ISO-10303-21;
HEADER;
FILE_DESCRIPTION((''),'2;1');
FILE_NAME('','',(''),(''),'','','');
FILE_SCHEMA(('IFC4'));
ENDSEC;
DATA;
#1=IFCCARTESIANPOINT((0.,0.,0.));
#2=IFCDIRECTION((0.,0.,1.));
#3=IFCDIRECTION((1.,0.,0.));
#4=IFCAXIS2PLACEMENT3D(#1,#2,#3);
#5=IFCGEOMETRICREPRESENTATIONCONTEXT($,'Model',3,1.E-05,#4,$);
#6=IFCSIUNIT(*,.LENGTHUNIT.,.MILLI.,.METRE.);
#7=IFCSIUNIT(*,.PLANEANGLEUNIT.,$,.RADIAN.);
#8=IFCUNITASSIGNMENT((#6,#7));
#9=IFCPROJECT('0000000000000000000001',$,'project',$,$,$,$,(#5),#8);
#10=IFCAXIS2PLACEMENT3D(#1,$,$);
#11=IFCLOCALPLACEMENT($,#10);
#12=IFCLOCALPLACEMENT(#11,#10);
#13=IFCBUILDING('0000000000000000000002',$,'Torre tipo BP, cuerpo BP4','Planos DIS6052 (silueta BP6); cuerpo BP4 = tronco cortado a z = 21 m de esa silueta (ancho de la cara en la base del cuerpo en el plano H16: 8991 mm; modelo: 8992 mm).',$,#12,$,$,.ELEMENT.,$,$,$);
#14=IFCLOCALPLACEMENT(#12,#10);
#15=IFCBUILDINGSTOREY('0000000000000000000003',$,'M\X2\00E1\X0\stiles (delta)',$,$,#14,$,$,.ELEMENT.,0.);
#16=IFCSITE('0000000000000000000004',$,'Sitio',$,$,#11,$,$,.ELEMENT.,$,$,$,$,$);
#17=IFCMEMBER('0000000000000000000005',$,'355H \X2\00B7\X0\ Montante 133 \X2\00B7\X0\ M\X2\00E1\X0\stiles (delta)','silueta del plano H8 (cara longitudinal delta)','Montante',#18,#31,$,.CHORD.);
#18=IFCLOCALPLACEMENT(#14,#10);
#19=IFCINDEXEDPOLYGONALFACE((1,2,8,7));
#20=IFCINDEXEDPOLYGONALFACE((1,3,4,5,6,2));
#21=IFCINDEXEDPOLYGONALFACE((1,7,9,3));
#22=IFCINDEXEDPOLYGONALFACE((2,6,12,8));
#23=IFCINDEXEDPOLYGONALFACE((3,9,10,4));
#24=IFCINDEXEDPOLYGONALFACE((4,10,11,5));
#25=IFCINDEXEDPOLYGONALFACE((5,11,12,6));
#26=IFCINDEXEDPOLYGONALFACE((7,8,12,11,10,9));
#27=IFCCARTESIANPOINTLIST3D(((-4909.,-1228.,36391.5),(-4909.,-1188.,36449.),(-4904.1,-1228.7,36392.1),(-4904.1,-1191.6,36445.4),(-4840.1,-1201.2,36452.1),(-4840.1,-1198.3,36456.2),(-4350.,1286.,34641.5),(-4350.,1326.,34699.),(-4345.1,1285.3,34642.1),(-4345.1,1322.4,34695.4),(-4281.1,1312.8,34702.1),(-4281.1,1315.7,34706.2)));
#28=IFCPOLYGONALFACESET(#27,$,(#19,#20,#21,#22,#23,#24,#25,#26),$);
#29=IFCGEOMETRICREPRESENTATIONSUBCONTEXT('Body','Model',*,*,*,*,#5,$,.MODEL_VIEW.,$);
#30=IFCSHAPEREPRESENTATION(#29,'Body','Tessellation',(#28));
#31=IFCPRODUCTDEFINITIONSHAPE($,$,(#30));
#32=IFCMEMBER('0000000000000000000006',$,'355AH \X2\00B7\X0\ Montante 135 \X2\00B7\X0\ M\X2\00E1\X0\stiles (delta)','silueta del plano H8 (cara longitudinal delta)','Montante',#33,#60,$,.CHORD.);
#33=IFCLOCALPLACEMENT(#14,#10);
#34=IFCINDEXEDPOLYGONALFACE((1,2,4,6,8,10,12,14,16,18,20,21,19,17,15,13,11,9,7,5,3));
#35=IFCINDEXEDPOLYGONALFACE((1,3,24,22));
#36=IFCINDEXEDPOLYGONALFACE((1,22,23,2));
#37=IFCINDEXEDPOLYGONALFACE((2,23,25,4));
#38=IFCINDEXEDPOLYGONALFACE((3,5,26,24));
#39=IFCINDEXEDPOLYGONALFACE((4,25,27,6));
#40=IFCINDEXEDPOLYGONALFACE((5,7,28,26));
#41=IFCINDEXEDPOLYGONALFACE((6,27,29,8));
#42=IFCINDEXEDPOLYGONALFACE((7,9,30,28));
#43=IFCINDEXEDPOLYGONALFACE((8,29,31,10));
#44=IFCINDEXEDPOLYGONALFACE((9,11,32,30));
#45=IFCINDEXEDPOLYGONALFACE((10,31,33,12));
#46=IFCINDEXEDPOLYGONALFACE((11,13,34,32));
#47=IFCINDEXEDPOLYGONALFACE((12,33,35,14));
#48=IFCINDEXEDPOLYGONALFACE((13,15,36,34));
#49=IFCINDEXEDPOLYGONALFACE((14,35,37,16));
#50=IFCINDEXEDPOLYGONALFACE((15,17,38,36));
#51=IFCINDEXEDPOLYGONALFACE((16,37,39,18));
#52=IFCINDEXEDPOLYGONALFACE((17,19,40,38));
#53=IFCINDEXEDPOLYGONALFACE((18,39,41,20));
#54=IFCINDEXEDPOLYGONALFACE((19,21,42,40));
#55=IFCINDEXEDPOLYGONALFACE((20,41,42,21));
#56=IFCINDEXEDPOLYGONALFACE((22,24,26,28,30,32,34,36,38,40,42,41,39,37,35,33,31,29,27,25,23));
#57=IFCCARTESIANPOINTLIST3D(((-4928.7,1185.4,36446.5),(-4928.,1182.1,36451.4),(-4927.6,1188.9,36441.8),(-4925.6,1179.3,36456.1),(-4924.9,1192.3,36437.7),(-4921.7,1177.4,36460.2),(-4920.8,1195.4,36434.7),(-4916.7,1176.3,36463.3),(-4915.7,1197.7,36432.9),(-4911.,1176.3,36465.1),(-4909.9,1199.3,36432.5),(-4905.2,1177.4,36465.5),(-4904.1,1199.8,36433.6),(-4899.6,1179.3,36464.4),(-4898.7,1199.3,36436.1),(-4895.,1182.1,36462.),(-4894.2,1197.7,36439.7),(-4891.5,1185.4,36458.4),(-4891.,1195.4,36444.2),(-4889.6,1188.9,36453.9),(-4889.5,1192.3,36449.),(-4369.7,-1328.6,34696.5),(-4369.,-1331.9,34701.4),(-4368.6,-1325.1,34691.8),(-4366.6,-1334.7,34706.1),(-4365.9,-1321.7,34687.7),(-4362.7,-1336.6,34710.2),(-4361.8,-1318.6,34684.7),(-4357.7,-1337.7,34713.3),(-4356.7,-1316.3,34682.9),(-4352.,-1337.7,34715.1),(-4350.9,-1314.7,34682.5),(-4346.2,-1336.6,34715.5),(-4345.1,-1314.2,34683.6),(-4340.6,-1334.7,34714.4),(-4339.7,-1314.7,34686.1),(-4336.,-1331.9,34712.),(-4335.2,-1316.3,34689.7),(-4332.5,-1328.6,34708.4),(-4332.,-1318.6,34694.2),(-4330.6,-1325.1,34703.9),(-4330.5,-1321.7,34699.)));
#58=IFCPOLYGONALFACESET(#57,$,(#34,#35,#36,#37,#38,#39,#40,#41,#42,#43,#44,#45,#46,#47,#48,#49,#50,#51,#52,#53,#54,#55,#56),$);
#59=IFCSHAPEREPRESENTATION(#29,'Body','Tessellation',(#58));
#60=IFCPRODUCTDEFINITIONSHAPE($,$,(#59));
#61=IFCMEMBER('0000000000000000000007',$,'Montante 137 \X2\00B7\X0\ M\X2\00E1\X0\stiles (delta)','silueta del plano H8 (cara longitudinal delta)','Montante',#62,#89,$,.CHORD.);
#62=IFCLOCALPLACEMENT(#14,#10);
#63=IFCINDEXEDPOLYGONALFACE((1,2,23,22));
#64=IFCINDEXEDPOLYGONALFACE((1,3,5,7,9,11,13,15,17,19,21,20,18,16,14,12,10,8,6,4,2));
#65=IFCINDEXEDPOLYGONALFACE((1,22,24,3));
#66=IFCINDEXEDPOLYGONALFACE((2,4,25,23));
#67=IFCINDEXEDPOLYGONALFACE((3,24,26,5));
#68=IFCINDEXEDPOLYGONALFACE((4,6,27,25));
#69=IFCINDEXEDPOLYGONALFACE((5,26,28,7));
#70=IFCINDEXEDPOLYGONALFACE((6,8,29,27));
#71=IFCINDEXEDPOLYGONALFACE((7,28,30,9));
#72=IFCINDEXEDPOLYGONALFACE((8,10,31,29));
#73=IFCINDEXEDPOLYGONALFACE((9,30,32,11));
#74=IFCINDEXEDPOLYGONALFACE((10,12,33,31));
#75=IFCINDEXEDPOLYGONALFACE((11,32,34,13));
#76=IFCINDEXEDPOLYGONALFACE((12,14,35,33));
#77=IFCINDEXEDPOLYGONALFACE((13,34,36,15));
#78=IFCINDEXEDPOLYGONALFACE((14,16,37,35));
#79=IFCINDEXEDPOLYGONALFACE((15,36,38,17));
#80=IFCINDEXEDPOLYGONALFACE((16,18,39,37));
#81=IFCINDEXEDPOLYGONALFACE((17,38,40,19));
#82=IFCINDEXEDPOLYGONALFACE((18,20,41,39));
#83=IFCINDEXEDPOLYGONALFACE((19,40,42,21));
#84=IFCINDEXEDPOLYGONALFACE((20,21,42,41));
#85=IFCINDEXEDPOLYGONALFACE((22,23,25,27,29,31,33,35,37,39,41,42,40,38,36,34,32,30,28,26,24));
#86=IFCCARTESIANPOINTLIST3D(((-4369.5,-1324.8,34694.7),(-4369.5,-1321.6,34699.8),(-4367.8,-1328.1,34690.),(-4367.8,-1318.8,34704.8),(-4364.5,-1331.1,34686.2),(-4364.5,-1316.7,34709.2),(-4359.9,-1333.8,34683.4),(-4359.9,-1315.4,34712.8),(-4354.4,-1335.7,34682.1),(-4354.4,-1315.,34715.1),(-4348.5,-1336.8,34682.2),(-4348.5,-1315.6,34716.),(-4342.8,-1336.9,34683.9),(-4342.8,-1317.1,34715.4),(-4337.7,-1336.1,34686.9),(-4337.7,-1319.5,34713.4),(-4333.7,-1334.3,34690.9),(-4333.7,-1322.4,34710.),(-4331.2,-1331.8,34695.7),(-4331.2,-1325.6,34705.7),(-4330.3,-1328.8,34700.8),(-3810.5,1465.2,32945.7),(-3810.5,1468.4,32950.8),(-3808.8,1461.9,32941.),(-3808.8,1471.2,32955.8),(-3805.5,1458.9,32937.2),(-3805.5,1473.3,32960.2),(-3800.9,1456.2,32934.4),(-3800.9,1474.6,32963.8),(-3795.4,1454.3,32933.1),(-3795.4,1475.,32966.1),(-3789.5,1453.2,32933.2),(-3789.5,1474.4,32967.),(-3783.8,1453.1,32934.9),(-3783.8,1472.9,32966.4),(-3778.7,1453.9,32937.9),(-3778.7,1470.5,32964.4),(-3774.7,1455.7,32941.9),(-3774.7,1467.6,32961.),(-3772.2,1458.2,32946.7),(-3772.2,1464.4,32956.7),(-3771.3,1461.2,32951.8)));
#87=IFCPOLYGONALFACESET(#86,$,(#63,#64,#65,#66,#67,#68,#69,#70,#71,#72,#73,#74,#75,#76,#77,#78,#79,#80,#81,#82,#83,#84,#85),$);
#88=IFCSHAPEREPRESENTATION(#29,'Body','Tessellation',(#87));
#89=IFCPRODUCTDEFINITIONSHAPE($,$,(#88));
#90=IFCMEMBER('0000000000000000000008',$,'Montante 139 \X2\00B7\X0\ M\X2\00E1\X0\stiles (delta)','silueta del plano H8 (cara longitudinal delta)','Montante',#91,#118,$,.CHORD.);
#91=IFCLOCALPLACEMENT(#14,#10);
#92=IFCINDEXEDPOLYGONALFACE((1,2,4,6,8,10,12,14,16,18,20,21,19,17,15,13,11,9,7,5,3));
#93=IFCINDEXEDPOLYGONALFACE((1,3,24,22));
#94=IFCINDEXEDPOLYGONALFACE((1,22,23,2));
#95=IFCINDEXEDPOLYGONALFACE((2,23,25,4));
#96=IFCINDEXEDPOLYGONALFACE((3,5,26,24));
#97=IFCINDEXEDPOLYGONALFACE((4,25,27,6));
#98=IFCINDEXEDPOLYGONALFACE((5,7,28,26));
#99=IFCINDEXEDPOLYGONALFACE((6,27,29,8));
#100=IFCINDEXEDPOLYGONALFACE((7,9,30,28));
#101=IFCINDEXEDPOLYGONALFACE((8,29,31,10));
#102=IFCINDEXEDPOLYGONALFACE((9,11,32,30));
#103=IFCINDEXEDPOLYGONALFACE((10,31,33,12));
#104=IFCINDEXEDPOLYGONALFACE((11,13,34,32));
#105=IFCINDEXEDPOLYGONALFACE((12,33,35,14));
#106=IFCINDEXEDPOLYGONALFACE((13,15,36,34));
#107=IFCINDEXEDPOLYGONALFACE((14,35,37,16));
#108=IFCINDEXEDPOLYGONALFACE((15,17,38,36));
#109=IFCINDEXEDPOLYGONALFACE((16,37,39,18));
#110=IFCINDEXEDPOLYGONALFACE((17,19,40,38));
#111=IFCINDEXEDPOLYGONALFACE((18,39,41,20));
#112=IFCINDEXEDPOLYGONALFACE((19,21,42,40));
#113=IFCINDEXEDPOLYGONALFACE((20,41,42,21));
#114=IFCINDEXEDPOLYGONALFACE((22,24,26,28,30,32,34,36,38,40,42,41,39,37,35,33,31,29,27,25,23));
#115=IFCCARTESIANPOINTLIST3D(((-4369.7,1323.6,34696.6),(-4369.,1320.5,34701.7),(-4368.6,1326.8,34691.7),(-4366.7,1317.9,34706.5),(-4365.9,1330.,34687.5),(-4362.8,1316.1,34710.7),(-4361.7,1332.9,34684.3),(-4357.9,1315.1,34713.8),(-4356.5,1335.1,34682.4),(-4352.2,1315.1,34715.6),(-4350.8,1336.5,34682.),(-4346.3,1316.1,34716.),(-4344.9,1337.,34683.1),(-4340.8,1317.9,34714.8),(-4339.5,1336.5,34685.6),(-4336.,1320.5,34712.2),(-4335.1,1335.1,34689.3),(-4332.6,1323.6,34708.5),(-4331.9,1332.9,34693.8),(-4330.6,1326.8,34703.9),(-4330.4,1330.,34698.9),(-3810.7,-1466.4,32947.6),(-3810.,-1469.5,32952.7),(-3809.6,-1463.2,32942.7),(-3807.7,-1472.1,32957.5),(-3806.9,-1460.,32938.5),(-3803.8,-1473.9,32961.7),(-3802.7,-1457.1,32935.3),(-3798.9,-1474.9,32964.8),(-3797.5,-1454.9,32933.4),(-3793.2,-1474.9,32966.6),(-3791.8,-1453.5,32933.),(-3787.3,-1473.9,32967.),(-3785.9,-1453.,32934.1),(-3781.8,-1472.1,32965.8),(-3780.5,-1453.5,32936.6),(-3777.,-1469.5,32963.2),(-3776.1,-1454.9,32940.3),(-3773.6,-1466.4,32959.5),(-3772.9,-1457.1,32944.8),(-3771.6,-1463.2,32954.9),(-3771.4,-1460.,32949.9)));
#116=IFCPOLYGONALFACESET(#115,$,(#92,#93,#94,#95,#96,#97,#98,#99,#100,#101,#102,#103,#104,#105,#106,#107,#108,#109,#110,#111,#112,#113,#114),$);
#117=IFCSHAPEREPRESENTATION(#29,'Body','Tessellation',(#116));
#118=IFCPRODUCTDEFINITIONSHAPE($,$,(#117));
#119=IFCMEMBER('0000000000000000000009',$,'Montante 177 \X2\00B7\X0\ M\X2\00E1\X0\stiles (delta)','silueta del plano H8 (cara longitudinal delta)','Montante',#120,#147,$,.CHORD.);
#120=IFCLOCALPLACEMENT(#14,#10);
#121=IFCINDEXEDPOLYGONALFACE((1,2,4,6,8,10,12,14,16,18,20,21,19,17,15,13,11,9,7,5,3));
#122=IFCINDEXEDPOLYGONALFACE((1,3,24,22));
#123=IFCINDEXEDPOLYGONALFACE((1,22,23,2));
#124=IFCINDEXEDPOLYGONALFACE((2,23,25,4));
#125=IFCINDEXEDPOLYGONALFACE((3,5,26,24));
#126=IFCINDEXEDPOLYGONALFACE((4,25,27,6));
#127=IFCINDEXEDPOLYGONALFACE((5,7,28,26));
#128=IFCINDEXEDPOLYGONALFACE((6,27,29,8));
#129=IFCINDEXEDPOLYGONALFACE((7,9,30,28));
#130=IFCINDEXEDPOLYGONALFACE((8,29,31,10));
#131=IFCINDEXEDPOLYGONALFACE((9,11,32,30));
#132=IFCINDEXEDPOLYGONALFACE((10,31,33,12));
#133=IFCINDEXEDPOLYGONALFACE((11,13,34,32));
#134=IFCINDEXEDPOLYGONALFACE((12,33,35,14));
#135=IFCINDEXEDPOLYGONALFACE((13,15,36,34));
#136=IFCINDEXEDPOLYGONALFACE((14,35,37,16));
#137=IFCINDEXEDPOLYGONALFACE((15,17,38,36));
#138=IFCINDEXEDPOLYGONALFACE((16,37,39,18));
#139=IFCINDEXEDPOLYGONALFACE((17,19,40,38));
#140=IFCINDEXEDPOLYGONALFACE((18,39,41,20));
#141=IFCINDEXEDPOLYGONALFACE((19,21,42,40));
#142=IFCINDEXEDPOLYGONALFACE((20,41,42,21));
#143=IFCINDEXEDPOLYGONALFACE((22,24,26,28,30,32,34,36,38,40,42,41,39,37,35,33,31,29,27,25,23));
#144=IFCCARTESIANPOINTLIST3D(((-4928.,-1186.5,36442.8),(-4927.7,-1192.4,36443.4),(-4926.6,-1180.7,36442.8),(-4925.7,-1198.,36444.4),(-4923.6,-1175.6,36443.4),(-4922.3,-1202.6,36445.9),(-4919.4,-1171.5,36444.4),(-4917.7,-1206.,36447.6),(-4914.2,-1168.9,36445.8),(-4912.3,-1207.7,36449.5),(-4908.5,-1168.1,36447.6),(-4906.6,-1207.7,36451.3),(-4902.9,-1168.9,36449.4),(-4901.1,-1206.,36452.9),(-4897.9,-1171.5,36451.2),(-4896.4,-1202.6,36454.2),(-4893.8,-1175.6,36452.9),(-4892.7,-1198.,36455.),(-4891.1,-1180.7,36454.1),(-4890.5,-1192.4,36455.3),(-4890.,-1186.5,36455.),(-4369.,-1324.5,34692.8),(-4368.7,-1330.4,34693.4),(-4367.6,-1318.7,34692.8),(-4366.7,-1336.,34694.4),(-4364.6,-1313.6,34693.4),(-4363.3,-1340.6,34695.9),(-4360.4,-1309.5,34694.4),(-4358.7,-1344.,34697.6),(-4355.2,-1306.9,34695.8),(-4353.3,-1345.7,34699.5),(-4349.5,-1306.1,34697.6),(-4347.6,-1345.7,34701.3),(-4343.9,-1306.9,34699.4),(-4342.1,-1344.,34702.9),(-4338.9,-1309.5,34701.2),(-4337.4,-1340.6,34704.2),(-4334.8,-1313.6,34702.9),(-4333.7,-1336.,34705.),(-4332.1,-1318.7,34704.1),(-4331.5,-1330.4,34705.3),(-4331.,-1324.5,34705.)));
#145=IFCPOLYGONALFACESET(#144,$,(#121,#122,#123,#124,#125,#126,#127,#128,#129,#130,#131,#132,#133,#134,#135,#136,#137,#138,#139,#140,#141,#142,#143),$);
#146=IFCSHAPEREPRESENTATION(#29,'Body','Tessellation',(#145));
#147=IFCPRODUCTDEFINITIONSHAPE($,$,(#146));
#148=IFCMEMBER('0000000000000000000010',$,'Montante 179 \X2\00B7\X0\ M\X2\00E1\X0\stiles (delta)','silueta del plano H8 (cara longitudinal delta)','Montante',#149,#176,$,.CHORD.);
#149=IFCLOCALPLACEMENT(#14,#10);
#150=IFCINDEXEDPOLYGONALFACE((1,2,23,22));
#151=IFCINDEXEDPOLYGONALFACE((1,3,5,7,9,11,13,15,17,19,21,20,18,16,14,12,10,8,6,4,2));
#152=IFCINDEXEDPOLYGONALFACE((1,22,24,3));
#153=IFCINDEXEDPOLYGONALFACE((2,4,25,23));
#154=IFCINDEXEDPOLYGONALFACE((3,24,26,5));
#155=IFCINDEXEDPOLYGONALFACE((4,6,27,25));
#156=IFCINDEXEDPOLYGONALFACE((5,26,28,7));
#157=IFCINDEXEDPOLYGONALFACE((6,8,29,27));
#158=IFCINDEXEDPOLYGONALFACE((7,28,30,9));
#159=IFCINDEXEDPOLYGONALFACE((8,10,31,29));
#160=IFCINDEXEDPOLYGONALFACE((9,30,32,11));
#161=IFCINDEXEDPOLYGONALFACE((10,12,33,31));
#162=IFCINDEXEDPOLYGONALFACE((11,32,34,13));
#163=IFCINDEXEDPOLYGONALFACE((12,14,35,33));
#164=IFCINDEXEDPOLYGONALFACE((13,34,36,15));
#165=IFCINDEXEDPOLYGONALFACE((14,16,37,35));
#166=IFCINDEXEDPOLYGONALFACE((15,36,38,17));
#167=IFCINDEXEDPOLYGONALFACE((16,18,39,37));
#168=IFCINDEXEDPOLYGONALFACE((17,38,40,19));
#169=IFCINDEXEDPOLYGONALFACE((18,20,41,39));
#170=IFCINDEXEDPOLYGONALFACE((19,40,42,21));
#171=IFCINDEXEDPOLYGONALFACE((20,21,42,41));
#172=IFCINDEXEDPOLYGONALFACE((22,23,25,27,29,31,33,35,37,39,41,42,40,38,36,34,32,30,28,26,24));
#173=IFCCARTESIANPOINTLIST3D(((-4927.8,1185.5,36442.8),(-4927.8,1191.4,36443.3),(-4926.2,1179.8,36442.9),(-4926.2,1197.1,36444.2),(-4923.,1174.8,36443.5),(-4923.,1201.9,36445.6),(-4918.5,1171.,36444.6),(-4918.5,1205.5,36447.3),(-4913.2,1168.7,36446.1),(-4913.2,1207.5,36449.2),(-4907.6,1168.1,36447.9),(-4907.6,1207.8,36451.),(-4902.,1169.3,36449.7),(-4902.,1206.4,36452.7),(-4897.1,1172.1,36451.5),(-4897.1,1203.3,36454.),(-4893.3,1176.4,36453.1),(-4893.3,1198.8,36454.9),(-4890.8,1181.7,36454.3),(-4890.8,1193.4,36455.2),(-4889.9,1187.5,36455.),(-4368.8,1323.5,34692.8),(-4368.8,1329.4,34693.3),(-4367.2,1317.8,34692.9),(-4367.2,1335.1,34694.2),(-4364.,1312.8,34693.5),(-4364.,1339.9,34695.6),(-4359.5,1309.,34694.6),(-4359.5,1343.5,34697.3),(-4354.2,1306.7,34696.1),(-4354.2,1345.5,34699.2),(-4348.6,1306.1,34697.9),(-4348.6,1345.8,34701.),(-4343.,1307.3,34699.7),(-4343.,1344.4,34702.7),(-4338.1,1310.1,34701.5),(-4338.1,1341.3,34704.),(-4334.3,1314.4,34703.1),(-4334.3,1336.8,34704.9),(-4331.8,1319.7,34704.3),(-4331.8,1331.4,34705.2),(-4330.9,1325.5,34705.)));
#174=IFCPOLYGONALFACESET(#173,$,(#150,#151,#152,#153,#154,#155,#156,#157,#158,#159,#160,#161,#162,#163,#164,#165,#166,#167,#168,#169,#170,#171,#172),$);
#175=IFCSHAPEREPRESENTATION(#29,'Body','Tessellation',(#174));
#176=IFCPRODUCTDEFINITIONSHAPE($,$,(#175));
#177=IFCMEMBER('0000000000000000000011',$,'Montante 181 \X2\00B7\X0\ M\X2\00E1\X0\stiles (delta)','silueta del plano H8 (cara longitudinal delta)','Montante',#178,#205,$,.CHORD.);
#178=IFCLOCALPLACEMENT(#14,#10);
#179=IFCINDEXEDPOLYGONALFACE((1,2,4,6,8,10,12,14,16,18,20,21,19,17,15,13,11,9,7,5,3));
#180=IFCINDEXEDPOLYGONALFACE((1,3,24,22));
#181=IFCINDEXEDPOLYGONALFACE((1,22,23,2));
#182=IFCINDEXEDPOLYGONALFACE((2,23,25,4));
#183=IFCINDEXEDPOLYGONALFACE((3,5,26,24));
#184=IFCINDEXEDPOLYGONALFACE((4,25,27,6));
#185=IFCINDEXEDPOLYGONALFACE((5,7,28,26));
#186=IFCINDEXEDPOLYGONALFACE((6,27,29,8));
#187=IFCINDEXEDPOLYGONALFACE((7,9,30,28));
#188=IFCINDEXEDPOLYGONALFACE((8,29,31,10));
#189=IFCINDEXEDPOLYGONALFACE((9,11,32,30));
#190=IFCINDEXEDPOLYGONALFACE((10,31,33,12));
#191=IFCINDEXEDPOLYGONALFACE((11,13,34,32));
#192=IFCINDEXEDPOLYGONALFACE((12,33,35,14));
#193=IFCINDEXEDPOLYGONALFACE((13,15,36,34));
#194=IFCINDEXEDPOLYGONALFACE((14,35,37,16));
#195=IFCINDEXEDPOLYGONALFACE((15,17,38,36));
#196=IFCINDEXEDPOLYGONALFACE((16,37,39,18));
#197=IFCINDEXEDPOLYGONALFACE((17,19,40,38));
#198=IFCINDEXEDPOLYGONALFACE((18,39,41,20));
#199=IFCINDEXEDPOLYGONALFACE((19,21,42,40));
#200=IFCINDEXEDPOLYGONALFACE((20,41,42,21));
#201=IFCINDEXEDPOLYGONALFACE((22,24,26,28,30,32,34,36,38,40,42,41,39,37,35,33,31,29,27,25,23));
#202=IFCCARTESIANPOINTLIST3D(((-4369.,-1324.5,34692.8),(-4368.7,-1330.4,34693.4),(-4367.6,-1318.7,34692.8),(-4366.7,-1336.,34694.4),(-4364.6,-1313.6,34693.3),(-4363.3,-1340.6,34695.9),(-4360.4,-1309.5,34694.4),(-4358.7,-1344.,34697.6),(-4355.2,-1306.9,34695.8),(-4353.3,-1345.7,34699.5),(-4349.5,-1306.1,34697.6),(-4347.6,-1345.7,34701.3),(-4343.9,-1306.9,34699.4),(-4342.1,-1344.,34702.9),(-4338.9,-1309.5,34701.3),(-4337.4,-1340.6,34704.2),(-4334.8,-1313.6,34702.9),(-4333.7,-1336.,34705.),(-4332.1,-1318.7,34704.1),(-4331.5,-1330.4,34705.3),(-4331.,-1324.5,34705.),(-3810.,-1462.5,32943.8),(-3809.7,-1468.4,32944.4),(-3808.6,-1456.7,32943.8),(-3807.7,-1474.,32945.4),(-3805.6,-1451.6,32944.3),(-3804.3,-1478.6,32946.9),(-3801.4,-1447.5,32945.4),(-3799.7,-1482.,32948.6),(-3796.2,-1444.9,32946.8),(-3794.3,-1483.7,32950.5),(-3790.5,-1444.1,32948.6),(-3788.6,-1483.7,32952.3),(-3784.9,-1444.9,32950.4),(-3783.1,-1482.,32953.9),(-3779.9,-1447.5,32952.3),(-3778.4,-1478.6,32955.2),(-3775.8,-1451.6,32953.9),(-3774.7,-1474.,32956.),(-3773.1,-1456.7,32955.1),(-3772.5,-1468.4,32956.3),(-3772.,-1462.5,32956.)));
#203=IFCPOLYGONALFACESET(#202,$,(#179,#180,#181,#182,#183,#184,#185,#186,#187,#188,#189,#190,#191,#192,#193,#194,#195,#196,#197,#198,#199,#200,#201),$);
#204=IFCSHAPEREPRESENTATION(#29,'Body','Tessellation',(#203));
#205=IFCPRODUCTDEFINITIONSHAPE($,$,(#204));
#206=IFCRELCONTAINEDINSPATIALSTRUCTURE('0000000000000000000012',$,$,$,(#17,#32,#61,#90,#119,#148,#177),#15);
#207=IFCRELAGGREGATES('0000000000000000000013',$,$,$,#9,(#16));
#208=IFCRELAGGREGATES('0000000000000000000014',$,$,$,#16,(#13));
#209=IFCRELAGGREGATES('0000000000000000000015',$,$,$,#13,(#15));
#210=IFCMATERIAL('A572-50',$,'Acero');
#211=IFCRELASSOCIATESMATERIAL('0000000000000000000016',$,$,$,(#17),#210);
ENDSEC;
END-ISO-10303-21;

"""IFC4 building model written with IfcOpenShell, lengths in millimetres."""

from ifc_helpers import new_model, si_unit, frame, frame_2d, origin, origin_with_axes, place, context, subcontext, project, spatial, circle, l_section, extrude, material, element, save


model = new_model("IFC4")

# Units and contexts
model_context = context("Model", 3, precision=1e-05, world=origin_with_axes())
body_context = subcontext(model_context, "Body", "Model", "MODEL_VIEW")
ifc_project = project(units=[si_unit("LENGTHUNIT", "METRE", prefix="MILLI"), si_unit("PLANEANGLEUNIT", "RADIAN")], contexts=[model_context])

# Site, building, storey
site_placement = place(None, origin())
site = spatial("IfcSite", under=ifc_project, at=site_placement, Name="Sitio", CompositionType="ELEMENT")
building_placement = place(site_placement, origin())
building = spatial("IfcBuilding", under=site, at=building_placement, Name="Torre tipo BP, cuerpo BP4", Description="Planos DIS6052 (silueta BP6); cuerpo BP4 = tronco cortado a z = 21 m de esa silueta (ancho de la cara en la base del cuerpo en el plano H16: 8991 mm; modelo: 8992 mm).", CompositionType="ELEMENT")
storey_placement = place(building_placement, origin())
storey = spatial("IfcBuildingStorey", under=building, at=storey_placement, Name="Mástiles (delta)", CompositionType="ELEMENT", Elevation=0.0)

# Members
ifc_material = material(Name="A572-50", Category="Acero")
member_1_placement = place(storey_placement, frame((-4909.0, -1188.0, 36449.0), z_axis=(0.179529, 0.807398, -0.562031), x_axis=(0.983753, -0.147345, 0.102567)))
element("IfcMember", 1, at=member_1_placement, inside=storey, material=ifc_material, Name="355H · Montante 133 · Mástiles (delta)", Description="silueta del plano H8 (cara longitudinal delta)", ObjectType="Montante", PredefinedType="CHORD", context=body_context, shape_type="SweptSolid", body=[
    extrude(l_section(Depth=70.0, Width=70.0, Thickness=5.0, at=frame_2d((35.0, 35.0))), None, (0.0, 0.0, 1.0), 3113.7),
])
member_2_placement = place(storey_placement, frame((-4909.0, 1188.0, 36449.0), z_axis=(0.179529, -0.807398, -0.562031), x_axis=(0.245676, 0.590008, -0.769112)))
element("IfcMember", 2, at=member_2_placement, inside=storey, Name="355AH · Montante 135 · Mástiles (delta)", Description="silueta del plano H8 (cara longitudinal delta)", ObjectType="Montante", PredefinedType="CHORD", context=body_context, shape_type="SweptSolid", body=[
    extrude(circle(Radius=20.0), None, (0.0, 0.0, 1.0), 3113.7),
])
for number, where, z_axis, x_axis, name in (
    (3, (-4350.0, -1326.0, 34699.0), (0.167365, 0.83533, -0.523653), (0.985895, -0.141806, 0.088895), "Montante 137 · Mástiles (delta)"),
    (4, (-4350.0, 1326.0, 34699.0), (0.167365, -0.83533, -0.523653), (0.254308, 0.549749, -0.795678), "Montante 139 · Mástiles (delta)"),
):
    element("IfcMember", number, at=place(storey_placement, frame(where, z_axis=z_axis, x_axis=x_axis)), inside=storey, Name=name, Description="silueta del plano H8 (cara longitudinal delta)", ObjectType="Montante", PredefinedType="CHORD", context=body_context, shape_type="SweptSolid", body=[
        extrude(circle(Radius=20.0), None, (0.0, 0.0, 1.0), 3340.0),
    ])
for number, where, z_axis, x_axis, name in (
    (5, (-4909.0, -1188.0, 36449.0), (0.303427, -0.074907, -0.949906), (0.022793, 0.997191, -0.071355), "Montante 177 · Mástiles (delta)"),
    (6, (-4909.0, 1188.0, 36449.0), (0.303427, 0.074907, -0.949906), (0.952855, -0.023853, 0.302488), "Montante 179 · Mástiles (delta)"),
):
    element("IfcMember", number, at=place(storey_placement, frame(where, z_axis=z_axis, x_axis=x_axis)), inside=storey, Name=name, Description="silueta del plano H8 (cara longitudinal delta)", ObjectType="Montante", PredefinedType="CHORD", context=body_context, shape_type="SweptSolid", body=[
        extrude(circle(Radius=20.0), None, (0.0, 0.0, 1.0), 1842.3),
    ])
for number, where, z_axis, x_axis, name in (
    (7, (-4350.0, -1326.0, 34699.0), (0.303584, -0.074945, -0.949853), (0.022816, 0.997188, -0.071388), "Montante 181 · Mástiles (delta)"),
):
    element("IfcMember", number, at=place(storey_placement, frame(where, z_axis=z_axis, x_axis=x_axis)), inside=storey, Name=name, Description="silueta del plano H8 (cara longitudinal delta)", ObjectType="Montante", PredefinedType="CHORD", context=body_context, shape_type="SweptSolid", body=[
        extrude(circle(Radius=20.0), None, (0.0, 0.0, 1.0), 1841.3),
    ])

save(model, "model.ifc")
